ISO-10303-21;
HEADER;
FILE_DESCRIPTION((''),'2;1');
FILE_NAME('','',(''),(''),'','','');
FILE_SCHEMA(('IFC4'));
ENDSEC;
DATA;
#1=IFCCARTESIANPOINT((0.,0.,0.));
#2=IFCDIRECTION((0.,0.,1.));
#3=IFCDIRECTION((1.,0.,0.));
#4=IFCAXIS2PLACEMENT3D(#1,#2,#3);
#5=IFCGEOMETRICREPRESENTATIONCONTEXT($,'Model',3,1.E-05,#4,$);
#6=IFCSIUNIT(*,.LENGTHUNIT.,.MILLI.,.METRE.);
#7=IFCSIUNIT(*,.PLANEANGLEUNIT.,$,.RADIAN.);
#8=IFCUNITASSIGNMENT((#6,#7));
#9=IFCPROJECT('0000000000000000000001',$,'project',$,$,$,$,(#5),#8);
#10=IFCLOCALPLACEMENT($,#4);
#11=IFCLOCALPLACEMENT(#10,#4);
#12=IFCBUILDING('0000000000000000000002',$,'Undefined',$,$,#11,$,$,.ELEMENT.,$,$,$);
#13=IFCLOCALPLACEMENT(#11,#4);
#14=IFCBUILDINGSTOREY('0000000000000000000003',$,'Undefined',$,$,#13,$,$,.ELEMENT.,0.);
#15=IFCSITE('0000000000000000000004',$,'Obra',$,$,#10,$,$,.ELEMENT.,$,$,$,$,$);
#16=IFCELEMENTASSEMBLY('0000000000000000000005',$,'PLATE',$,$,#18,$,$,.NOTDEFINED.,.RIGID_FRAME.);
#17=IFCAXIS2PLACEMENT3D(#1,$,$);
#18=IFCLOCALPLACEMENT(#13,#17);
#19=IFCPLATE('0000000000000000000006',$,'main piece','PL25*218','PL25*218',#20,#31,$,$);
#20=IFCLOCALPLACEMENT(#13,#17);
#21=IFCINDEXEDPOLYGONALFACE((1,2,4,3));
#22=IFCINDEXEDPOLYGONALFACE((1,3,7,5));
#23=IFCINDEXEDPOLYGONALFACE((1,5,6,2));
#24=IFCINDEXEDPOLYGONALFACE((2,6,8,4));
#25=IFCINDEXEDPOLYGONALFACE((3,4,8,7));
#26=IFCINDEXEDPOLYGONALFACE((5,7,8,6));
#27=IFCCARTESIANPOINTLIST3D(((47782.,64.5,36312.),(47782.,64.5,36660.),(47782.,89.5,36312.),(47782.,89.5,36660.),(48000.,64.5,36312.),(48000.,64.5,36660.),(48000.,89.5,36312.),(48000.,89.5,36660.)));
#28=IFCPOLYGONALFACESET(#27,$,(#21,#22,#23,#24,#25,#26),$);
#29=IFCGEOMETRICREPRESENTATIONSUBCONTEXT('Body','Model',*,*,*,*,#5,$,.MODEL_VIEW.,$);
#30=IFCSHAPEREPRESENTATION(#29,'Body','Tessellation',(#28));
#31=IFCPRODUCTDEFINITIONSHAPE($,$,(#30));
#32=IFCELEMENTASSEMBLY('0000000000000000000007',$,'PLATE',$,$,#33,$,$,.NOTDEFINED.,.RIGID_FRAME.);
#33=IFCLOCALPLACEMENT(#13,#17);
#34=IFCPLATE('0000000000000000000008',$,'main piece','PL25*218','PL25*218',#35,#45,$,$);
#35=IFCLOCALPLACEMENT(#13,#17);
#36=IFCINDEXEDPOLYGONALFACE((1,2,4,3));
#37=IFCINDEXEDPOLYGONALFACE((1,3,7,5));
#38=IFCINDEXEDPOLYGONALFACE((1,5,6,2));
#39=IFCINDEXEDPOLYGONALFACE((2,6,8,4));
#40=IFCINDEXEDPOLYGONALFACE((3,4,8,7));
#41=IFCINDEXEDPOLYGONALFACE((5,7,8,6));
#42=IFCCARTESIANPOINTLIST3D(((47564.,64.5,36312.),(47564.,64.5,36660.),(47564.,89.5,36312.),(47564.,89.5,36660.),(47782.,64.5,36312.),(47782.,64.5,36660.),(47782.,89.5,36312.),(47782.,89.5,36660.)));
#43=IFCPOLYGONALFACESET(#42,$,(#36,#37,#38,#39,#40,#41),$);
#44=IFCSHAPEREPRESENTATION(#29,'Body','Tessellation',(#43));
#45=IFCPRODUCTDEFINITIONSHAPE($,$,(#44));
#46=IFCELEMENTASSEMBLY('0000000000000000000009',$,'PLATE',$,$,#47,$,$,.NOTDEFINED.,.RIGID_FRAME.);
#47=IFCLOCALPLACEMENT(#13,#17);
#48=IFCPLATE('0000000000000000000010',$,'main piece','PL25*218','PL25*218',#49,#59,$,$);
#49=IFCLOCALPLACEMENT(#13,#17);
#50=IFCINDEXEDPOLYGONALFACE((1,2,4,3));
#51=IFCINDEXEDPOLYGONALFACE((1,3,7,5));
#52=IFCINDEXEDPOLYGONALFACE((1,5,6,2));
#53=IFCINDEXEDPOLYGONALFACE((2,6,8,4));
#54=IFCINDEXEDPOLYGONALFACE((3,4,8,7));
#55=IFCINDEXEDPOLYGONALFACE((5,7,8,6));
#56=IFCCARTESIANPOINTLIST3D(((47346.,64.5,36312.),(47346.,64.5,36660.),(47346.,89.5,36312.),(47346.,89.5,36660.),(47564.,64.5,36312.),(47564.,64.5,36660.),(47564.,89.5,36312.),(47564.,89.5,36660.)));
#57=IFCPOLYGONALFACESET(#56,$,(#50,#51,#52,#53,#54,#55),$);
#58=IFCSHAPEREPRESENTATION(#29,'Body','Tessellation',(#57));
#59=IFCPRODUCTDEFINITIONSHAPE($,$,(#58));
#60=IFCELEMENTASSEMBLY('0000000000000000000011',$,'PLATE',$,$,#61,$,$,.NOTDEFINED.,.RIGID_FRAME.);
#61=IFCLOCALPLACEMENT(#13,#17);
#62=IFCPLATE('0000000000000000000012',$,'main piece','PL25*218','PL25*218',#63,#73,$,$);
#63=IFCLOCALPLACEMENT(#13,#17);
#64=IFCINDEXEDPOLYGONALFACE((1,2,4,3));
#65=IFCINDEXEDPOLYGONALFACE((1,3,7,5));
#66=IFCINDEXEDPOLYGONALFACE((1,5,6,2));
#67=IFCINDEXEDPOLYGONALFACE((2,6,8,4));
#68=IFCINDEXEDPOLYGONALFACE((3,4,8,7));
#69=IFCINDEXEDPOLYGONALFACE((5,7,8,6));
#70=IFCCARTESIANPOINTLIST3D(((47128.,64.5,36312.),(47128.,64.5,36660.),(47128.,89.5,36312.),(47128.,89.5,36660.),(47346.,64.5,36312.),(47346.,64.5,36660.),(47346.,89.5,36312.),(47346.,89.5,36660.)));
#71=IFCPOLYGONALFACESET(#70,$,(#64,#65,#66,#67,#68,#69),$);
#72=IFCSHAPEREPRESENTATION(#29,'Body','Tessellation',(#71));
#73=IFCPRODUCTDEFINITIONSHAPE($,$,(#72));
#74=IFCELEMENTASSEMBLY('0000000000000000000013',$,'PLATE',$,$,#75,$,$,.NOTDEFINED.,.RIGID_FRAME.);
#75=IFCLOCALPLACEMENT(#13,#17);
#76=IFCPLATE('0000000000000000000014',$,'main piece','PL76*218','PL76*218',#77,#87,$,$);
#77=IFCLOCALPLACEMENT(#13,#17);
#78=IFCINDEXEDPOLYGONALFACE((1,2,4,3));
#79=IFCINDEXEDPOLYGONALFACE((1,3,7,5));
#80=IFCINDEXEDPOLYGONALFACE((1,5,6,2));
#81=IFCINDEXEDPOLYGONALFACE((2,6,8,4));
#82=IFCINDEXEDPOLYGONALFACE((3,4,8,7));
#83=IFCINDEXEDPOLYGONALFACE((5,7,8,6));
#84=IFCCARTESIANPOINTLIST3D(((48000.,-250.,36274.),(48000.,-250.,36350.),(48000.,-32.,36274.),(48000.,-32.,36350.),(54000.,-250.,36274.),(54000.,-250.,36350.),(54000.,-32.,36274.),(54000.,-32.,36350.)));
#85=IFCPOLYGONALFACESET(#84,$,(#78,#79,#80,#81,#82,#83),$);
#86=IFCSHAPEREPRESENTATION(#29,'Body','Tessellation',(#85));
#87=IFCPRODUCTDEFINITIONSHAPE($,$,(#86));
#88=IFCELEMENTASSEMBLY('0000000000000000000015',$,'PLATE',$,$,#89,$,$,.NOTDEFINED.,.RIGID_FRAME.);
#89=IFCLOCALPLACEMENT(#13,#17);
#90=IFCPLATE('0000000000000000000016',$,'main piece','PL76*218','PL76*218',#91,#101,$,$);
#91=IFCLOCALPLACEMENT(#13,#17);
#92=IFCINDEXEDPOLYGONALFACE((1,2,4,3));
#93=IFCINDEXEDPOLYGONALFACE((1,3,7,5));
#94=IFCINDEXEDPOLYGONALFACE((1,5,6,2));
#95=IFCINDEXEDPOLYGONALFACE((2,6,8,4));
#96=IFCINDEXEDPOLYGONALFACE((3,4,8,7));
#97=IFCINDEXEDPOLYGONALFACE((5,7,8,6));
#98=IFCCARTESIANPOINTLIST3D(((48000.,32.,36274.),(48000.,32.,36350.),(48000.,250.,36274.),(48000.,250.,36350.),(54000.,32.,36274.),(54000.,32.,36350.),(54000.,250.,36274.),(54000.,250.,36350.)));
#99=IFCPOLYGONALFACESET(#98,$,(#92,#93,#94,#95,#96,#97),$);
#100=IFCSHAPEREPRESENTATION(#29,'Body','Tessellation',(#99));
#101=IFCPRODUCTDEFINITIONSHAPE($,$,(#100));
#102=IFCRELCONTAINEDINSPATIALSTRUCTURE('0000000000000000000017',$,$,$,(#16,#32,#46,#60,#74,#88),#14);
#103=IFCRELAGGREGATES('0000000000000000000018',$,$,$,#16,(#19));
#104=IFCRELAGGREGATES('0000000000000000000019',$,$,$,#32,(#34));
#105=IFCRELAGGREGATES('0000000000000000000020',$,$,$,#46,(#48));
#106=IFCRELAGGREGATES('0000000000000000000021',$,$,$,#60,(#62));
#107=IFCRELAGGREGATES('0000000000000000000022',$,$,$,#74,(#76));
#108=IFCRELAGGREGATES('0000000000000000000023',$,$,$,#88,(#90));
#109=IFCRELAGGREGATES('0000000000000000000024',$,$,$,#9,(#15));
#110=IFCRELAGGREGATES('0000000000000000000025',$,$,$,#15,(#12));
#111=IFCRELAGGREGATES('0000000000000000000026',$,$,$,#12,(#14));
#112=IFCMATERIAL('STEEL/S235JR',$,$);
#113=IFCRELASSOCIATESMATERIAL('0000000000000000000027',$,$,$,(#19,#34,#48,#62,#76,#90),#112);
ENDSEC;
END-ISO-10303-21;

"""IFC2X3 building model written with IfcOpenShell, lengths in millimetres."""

from ifc_helpers import new_model, si_unit, frame, origin_with_axes, place, context, subcontext, project, spatial, polyline, outline, extrude, material, element, aggregate, save


model = new_model("IFC2X3")

# Units and contexts
model_context = context("Model", 3, precision=1e-05, world=origin_with_axes())
body_context = subcontext(model_context, "Body", "Model", "MODEL_VIEW")
ifc_project = project(units=[si_unit("LENGTHUNIT", "METRE", prefix="MILLI"), si_unit("PLANEANGLEUNIT", "RADIAN")], contexts=[model_context])

# Site, building, storey
site_placement = place(None, origin_with_axes())
site = spatial("IfcSite", under=ifc_project, at=site_placement, Name="Obra", CompositionType="ELEMENT")
building_placement = place(site_placement, origin_with_axes())
building = spatial("IfcBuilding", under=site, at=building_placement, Name="Undefined", CompositionType="ELEMENT")
storey_placement = place(building_placement, origin_with_axes())
storey = spatial("IfcBuildingStorey", under=building, at=storey_placement, Name="Undefined", CompositionType="ELEMENT", Elevation=0.0)

# Shared definitions
ifc_material = material(Name="STEEL/S235JR")

# Element assemblies, plates
assembly_1_placement = place(storey_placement, origin_with_axes())
assembly_1 = element("IfcElementAssembly", 1, at=assembly_1_placement, inside=storey, Name="PLATE", AssemblyPlace="NOTDEFINED", PredefinedType="RIGID_FRAME")
plate_1_placement = place(assembly_1_placement, frame((47782.0, 77.0, 36312.0), z_axis=(0.0, -1.0, 0.0), x_axis=(1.0, 0.0, 0.0)))
plate_1 = element("IfcPlate", 2, at=plate_1_placement, material=ifc_material, Name="main piece", Description="PL25*218", ObjectType="PL25*218", context=body_context, shape_type="SweptSolid", body=[
    extrude(outline(polyline([(0.0, 0.0), (218.0, 0.0), (218.0, 348.0), (0.0, 348.0), (0.0, 0.0)])), frame((0.0, 0.0, -12.5), z_axis=(0.0, 0.0, 1.0), x_axis=(1.0, 0.0, 0.0)), (0.0, 0.0, 1.0), 25.0),
])
aggregate(assembly_1, [plate_1])
assembly_2_placement = place(storey_placement, origin_with_axes())
assembly_2 = element("IfcElementAssembly", 3, at=assembly_2_placement, inside=storey, Name="PLATE", AssemblyPlace="NOTDEFINED", PredefinedType="RIGID_FRAME")
plate_2_placement = place(assembly_2_placement, frame((47564.0, 77.0, 36312.0), z_axis=(0.0, -1.0, 0.0), x_axis=(1.0, 0.0, 0.0)))
plate_2 = element("IfcPlate", 4, at=plate_2_placement, material=ifc_material, Name="main piece", Description="PL25*218", ObjectType="PL25*218", context=body_context, shape_type="SweptSolid", body=[
    extrude(outline(polyline([(0.0, 0.0), (218.0, 0.0), (218.0, 348.0), (0.0, 348.0), (0.0, 0.0)])), frame((0.0, 0.0, -12.5), z_axis=(0.0, 0.0, 1.0), x_axis=(1.0, 0.0, 0.0)), (0.0, 0.0, 1.0), 25.0),
])
aggregate(assembly_2, [plate_2])
assembly_3_placement = place(storey_placement, origin_with_axes())
assembly_3 = element("IfcElementAssembly", 5, at=assembly_3_placement, inside=storey, Name="PLATE", AssemblyPlace="NOTDEFINED", PredefinedType="RIGID_FRAME")
plate_3_placement = place(assembly_3_placement, frame((47346.0, 77.0, 36312.0), z_axis=(0.0, -1.0, 0.0), x_axis=(1.0, 0.0, 0.0)))
plate_3 = element("IfcPlate", 6, at=plate_3_placement, material=ifc_material, Name="main piece", Description="PL25*218", ObjectType="PL25*218", context=body_context, shape_type="SweptSolid", body=[
    extrude(outline(polyline([(0.0, 0.0), (218.0, 0.0), (218.0, 348.0), (0.0, 348.0), (0.0, 0.0)])), frame((0.0, 0.0, -12.5), z_axis=(0.0, 0.0, 1.0), x_axis=(1.0, 0.0, 0.0)), (0.0, 0.0, 1.0), 25.0),
])
aggregate(assembly_3, [plate_3])
assembly_4_placement = place(storey_placement, origin_with_axes())
assembly_4 = element("IfcElementAssembly", 7, at=assembly_4_placement, inside=storey, Name="PLATE", AssemblyPlace="NOTDEFINED", PredefinedType="RIGID_FRAME")
plate_4_placement = place(assembly_4_placement, frame((47128.0, 77.0, 36312.0), z_axis=(0.0, -1.0, 0.0), x_axis=(1.0, 0.0, 0.0)))
plate_4 = element("IfcPlate", 8, at=plate_4_placement, material=ifc_material, Name="main piece", Description="PL25*218", ObjectType="PL25*218", context=body_context, shape_type="SweptSolid", body=[
    extrude(outline(polyline([(0.0, 0.0), (218.0, 0.0), (218.0, 348.0), (0.0, 348.0), (0.0, 0.0)])), frame((0.0, 0.0, -12.5), z_axis=(0.0, 0.0, 1.0), x_axis=(1.0, 0.0, 0.0)), (0.0, 0.0, 1.0), 25.0),
])
aggregate(assembly_4, [plate_4])
assembly_5_placement = place(storey_placement, origin_with_axes())
assembly_5 = element("IfcElementAssembly", 9, at=assembly_5_placement, inside=storey, Name="PLATE", AssemblyPlace="NOTDEFINED", PredefinedType="RIGID_FRAME")
plate_5_placement = place(assembly_5_placement, frame((48000.0, -250.0, 36312.0), z_axis=(0.0, 0.0, -1.0), x_axis=(0.0, 1.0, 0.0)))
plate_5 = element("IfcPlate", 10, at=plate_5_placement, material=ifc_material, Name="main piece", Description="PL76*218", ObjectType="PL76*218", context=body_context, shape_type="SweptSolid", body=[
    extrude(outline(polyline([(0.0, 0.0), (218.0, 0.0), (218.0, 6000.0), (0.0, 6000.0), (0.0, 0.0)])), frame((0.0, 0.0, -38.0), z_axis=(0.0, 0.0, 1.0), x_axis=(1.0, 0.0, 0.0)), (0.0, 0.0, 1.0), 76.0),
])
aggregate(assembly_5, [plate_5])
assembly_6_placement = place(storey_placement, origin_with_axes())
assembly_6 = element("IfcElementAssembly", 11, at=assembly_6_placement, inside=storey, Name="PLATE", AssemblyPlace="NOTDEFINED", PredefinedType="RIGID_FRAME")
plate_6_placement = place(assembly_6_placement, frame((48000.0, 250.0, 36312.0), z_axis=(0.0, 0.0, 1.0), x_axis=(0.0, -1.0, 0.0)))
plate_6 = element("IfcPlate", 12, at=plate_6_placement, material=ifc_material, Name="main piece", Description="PL76*218", ObjectType="PL76*218", context=body_context, shape_type="SweptSolid", body=[
    extrude(outline(polyline([(0.0, 0.0), (218.0, 0.0), (218.0, 6000.0), (0.0, 6000.0), (0.0, 0.0)])), frame((0.0, 0.0, -38.0), z_axis=(0.0, 0.0, 1.0), x_axis=(1.0, 0.0, 0.0)), (0.0, 0.0, 1.0), 76.0),
])
aggregate(assembly_6, [plate_6])

save(model, "model.ifc")
